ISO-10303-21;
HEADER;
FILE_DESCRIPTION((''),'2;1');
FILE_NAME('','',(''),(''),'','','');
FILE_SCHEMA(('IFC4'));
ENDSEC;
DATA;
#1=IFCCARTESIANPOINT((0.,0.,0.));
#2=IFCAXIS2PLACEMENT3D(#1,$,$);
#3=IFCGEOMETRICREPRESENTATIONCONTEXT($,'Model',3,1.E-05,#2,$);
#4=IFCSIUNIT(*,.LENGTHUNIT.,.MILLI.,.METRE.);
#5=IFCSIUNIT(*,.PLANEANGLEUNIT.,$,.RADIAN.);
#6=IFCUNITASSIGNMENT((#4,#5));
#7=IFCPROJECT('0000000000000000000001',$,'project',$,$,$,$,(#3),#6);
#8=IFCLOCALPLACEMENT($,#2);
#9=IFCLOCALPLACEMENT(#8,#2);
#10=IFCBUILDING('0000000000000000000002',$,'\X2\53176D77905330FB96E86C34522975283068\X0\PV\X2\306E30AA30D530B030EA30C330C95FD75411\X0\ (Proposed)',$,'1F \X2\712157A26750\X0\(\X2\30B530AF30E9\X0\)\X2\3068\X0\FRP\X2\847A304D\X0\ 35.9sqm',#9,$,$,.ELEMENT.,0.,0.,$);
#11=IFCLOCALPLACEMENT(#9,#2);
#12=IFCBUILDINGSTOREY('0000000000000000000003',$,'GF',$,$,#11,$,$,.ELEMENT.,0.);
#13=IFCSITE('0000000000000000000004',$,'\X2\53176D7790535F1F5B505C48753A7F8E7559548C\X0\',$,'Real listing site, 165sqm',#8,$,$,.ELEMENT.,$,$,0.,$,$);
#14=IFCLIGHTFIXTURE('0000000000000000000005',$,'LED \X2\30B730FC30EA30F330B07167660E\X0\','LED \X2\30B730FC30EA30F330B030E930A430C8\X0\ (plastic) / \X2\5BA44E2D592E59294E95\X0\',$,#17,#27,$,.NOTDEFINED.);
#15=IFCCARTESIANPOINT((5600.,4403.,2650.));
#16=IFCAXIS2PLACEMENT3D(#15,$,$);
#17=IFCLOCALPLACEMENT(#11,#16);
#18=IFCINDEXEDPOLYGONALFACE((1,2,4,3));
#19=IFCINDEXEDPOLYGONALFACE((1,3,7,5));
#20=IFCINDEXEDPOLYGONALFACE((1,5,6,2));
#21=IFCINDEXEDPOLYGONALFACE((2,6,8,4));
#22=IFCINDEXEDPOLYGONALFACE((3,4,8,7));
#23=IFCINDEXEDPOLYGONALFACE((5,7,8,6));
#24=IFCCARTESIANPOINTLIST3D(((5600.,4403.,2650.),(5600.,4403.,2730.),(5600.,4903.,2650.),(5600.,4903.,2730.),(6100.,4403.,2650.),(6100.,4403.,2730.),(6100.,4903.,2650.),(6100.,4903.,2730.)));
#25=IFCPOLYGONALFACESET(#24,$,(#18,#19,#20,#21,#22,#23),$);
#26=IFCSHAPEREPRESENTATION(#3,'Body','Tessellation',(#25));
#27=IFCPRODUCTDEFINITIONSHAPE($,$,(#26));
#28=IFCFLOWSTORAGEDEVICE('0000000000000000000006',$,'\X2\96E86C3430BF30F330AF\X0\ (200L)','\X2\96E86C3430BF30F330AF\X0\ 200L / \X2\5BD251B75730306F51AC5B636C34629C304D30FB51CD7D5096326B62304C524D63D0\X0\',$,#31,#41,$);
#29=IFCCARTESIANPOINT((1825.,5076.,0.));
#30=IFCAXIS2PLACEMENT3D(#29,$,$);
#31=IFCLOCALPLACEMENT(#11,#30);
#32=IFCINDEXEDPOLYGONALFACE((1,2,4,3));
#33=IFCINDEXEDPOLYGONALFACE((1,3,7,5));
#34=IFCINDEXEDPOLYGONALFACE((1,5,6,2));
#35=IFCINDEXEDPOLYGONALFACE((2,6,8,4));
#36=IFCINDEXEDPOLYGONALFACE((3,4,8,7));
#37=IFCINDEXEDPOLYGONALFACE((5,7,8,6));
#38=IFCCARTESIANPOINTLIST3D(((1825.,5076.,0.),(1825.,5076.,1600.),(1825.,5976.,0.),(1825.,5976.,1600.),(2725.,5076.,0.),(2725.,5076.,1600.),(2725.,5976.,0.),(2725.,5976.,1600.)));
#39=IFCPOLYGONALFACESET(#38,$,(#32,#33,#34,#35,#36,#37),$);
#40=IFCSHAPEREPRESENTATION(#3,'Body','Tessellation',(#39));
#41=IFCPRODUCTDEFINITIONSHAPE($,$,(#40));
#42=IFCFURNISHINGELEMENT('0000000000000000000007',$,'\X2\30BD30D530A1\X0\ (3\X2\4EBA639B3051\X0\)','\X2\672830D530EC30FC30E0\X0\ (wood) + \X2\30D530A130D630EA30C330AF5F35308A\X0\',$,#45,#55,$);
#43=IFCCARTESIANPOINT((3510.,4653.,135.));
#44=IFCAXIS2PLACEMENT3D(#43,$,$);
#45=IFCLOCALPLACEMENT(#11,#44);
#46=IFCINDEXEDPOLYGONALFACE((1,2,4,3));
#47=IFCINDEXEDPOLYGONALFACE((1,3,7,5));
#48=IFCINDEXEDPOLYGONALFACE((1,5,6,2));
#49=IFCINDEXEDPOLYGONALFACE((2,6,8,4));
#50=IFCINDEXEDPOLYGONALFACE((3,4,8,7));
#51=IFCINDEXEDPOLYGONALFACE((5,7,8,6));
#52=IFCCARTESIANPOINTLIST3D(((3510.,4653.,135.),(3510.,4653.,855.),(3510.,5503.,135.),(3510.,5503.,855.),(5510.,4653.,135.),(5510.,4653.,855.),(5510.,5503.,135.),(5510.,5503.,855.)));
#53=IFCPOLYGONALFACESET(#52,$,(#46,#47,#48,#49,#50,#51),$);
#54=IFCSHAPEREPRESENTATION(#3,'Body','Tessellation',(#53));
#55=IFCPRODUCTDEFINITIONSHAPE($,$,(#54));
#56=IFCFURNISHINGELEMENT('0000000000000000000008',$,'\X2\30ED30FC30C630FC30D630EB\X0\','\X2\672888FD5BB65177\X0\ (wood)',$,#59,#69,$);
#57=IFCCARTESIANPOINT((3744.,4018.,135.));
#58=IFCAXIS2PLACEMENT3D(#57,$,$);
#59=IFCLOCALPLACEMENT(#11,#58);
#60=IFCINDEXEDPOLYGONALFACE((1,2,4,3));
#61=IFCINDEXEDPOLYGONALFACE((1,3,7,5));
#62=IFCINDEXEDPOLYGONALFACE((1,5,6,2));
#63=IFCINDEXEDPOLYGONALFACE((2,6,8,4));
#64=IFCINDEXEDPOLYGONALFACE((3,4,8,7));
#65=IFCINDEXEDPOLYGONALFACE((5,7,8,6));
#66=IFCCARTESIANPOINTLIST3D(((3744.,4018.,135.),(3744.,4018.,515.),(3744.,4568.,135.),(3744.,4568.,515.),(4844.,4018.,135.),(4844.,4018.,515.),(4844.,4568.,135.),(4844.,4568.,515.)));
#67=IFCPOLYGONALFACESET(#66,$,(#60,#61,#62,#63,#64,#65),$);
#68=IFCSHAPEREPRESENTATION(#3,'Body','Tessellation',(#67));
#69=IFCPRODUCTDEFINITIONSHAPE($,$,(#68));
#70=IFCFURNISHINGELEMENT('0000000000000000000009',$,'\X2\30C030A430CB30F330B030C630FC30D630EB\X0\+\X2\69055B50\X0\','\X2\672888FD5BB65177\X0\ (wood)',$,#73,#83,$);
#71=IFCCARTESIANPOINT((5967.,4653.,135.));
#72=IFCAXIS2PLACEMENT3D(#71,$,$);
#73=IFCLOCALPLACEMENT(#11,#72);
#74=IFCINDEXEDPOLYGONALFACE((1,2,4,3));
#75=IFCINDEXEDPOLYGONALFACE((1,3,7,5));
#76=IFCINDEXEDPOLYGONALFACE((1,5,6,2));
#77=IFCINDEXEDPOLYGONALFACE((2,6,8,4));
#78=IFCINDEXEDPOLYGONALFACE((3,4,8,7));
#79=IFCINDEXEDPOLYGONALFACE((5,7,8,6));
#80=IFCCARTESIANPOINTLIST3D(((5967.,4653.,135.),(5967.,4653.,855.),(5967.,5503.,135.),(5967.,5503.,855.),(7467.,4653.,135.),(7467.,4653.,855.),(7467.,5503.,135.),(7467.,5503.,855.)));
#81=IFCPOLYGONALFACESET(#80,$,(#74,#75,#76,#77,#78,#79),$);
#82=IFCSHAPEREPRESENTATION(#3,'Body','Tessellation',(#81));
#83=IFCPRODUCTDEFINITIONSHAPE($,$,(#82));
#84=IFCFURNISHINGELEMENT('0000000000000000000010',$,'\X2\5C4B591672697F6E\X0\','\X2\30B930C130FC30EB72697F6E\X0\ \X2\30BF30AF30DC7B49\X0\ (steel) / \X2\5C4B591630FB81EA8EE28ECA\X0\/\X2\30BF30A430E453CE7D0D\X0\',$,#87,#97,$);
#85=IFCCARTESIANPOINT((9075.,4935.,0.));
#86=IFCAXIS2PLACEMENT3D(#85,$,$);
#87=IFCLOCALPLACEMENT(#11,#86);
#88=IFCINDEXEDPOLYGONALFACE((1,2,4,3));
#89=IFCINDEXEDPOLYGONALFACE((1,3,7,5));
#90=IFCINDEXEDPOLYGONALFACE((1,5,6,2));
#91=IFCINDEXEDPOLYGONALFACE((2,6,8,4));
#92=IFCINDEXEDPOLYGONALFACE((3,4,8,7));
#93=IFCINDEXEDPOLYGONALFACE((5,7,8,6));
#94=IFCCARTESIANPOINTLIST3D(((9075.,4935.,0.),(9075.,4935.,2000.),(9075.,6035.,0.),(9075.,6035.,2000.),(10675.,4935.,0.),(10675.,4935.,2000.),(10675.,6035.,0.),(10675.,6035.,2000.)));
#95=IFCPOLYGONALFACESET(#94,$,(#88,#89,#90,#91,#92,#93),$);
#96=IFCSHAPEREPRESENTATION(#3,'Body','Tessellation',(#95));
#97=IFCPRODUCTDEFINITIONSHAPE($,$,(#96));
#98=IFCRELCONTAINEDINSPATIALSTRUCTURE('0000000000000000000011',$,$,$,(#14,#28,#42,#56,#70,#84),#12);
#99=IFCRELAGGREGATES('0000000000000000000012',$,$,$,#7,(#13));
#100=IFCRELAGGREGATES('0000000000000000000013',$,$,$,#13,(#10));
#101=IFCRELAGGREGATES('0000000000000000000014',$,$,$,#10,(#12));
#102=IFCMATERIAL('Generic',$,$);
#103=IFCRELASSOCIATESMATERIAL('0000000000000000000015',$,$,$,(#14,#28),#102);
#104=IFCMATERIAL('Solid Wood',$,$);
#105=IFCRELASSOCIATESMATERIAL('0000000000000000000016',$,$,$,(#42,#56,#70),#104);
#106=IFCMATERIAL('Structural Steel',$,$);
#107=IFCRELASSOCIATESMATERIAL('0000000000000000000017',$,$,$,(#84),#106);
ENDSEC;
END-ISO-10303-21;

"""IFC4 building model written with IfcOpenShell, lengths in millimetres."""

from ifc_helpers import new_model, si_unit, frame, frame_2d, origin, place, context, project, spatial, rectangle, extrude, material, element, save


model = new_model("IFC4")

# Units and contexts
model_context = context("Model", 3, precision=1e-05, world=origin())
ifc_project = project(units=[si_unit("LENGTHUNIT", "METRE", prefix="MILLI"), si_unit("PLANEANGLEUNIT", "RADIAN")], contexts=[model_context])

# Site, building, storey
site_placement = place(None, origin())
site = spatial("IfcSite", under=ifc_project, at=site_placement, Name="北海道弟子屈町美留和", ObjectType="Real listing site, 165sqm", CompositionType="ELEMENT", RefElevation=0.0)
building_placement = place(site_placement, origin())
building = spatial("IfcBuilding", under=site, at=building_placement, Name="北海道・雨水利用とPVのオフグリッド志向 (Proposed)", ObjectType="1F 無垢材(サクラ)とFRP葺き 35.9sqm", CompositionType="ELEMENT", ElevationOfRefHeight=0.0, ElevationOfTerrain=0.0)
storey_placement = place(building_placement, origin())
storey = spatial("IfcBuildingStorey", under=building, at=storey_placement, Name="GF", CompositionType="ELEMENT", Elevation=0.0)

# Shared definitions
ifc_material_1 = material(Name="Solid Wood")

# Shared definitions
ifc_material_2 = material(Name="Structural Steel")

# Light fixture
ifc_material_3 = material(Name="Generic")
light_fixture_placement = place(storey_placement, frame((5600.0, 4403.0, 2650.0)))
element("IfcLightFixture", 1, at=light_fixture_placement, inside=storey, material=ifc_material_3, Name="LED シーリング照明", Description="LED シーリングライト (plastic) / 室中央天井", PredefinedType="NOTDEFINED", context=model_context, shape_type="SweptSolid", body=[
    extrude(rectangle(XDim=500.0, YDim=500.0, at=frame_2d((250.0, 250.0))), frame((5600.0, 4403.0, 2650.0)), (0.0, 0.0, 1.0), 80.0),
])

# Flow storage device
flow_storage_device_placement = place(storey_placement, frame((1825.0, 5076.0, 0.0)))
element("IfcFlowStorageDevice", 2, at=flow_storage_device_placement, inside=storey, material=ifc_material_3, Name="雨水タンク (200L)", Description="雨水タンク 200L / 寒冷地は冬季水抜き・凍結防止が前提", context=model_context, shape_type="SweptSolid", body=[
    extrude(rectangle(XDim=900.0, YDim=900.0, at=frame_2d((450.0, 450.0))), frame((1825.0, 5076.0, 0.0)), (0.0, 0.0, 1.0), 1600.0),
])

# Furnishing elements
furnishing_1_placement = place(storey_placement, frame((3510.0, 4653.0, 135.0)))
element("IfcFurnishingElement", 3, at=furnishing_1_placement, inside=storey, material=ifc_material_1, Name="ソファ (3人掛け)", Description="木フレーム (wood) + ファブリック張り", context=model_context, shape_type="SweptSolid", body=[
    extrude(rectangle(XDim=2000.0, YDim=850.0, at=frame_2d((1000.0, 425.0))), frame((3510.0, 4653.0, 135.0)), (0.0, 0.0, 1.0), 720.0),
])
furnishing_2_placement = place(storey_placement, frame((3744.0, 4018.0, 135.0)))
element("IfcFurnishingElement", 4, at=furnishing_2_placement, inside=storey, material=ifc_material_1, Name="ローテーブル", Description="木製家具 (wood)", context=model_context, shape_type="SweptSolid", body=[
    extrude(rectangle(XDim=1100.0, YDim=550.0, at=frame_2d((550.0, 275.0))), frame((3744.0, 4018.0, 135.0)), (0.0, 0.0, 1.0), 380.0),
])
furnishing_3_placement = place(storey_placement, frame((5967.0, 4653.0, 135.0)))
element("IfcFurnishingElement", 5, at=furnishing_3_placement, inside=storey, material=ifc_material_1, Name="ダイニングテーブル+椅子", Description="木製家具 (wood)", context=model_context, shape_type="SweptSolid", body=[
    extrude(rectangle(XDim=1500.0, YDim=850.0, at=frame_2d((750.0, 425.0))), frame((5967.0, 4653.0, 135.0)), (0.0, 0.0, 1.0), 720.0),
])
furnishing_4_placement = place(storey_placement, frame((9075.0, 4935.0, 0.0)))
element("IfcFurnishingElement", 6, at=furnishing_4_placement, inside=storey, material=ifc_material_2, Name="屋外物置", Description="スチール物置 タクボ等 (steel) / 屋外・自転車/タイヤ収納", context=model_context, shape_type="SweptSolid", body=[
    extrude(rectangle(XDim=1600.0, YDim=1100.0, at=frame_2d((800.0, 550.0))), frame((9075.0, 4935.0, 0.0)), (0.0, 0.0, 1.0), 2000.0),
])

save(model, "model.ifc")
